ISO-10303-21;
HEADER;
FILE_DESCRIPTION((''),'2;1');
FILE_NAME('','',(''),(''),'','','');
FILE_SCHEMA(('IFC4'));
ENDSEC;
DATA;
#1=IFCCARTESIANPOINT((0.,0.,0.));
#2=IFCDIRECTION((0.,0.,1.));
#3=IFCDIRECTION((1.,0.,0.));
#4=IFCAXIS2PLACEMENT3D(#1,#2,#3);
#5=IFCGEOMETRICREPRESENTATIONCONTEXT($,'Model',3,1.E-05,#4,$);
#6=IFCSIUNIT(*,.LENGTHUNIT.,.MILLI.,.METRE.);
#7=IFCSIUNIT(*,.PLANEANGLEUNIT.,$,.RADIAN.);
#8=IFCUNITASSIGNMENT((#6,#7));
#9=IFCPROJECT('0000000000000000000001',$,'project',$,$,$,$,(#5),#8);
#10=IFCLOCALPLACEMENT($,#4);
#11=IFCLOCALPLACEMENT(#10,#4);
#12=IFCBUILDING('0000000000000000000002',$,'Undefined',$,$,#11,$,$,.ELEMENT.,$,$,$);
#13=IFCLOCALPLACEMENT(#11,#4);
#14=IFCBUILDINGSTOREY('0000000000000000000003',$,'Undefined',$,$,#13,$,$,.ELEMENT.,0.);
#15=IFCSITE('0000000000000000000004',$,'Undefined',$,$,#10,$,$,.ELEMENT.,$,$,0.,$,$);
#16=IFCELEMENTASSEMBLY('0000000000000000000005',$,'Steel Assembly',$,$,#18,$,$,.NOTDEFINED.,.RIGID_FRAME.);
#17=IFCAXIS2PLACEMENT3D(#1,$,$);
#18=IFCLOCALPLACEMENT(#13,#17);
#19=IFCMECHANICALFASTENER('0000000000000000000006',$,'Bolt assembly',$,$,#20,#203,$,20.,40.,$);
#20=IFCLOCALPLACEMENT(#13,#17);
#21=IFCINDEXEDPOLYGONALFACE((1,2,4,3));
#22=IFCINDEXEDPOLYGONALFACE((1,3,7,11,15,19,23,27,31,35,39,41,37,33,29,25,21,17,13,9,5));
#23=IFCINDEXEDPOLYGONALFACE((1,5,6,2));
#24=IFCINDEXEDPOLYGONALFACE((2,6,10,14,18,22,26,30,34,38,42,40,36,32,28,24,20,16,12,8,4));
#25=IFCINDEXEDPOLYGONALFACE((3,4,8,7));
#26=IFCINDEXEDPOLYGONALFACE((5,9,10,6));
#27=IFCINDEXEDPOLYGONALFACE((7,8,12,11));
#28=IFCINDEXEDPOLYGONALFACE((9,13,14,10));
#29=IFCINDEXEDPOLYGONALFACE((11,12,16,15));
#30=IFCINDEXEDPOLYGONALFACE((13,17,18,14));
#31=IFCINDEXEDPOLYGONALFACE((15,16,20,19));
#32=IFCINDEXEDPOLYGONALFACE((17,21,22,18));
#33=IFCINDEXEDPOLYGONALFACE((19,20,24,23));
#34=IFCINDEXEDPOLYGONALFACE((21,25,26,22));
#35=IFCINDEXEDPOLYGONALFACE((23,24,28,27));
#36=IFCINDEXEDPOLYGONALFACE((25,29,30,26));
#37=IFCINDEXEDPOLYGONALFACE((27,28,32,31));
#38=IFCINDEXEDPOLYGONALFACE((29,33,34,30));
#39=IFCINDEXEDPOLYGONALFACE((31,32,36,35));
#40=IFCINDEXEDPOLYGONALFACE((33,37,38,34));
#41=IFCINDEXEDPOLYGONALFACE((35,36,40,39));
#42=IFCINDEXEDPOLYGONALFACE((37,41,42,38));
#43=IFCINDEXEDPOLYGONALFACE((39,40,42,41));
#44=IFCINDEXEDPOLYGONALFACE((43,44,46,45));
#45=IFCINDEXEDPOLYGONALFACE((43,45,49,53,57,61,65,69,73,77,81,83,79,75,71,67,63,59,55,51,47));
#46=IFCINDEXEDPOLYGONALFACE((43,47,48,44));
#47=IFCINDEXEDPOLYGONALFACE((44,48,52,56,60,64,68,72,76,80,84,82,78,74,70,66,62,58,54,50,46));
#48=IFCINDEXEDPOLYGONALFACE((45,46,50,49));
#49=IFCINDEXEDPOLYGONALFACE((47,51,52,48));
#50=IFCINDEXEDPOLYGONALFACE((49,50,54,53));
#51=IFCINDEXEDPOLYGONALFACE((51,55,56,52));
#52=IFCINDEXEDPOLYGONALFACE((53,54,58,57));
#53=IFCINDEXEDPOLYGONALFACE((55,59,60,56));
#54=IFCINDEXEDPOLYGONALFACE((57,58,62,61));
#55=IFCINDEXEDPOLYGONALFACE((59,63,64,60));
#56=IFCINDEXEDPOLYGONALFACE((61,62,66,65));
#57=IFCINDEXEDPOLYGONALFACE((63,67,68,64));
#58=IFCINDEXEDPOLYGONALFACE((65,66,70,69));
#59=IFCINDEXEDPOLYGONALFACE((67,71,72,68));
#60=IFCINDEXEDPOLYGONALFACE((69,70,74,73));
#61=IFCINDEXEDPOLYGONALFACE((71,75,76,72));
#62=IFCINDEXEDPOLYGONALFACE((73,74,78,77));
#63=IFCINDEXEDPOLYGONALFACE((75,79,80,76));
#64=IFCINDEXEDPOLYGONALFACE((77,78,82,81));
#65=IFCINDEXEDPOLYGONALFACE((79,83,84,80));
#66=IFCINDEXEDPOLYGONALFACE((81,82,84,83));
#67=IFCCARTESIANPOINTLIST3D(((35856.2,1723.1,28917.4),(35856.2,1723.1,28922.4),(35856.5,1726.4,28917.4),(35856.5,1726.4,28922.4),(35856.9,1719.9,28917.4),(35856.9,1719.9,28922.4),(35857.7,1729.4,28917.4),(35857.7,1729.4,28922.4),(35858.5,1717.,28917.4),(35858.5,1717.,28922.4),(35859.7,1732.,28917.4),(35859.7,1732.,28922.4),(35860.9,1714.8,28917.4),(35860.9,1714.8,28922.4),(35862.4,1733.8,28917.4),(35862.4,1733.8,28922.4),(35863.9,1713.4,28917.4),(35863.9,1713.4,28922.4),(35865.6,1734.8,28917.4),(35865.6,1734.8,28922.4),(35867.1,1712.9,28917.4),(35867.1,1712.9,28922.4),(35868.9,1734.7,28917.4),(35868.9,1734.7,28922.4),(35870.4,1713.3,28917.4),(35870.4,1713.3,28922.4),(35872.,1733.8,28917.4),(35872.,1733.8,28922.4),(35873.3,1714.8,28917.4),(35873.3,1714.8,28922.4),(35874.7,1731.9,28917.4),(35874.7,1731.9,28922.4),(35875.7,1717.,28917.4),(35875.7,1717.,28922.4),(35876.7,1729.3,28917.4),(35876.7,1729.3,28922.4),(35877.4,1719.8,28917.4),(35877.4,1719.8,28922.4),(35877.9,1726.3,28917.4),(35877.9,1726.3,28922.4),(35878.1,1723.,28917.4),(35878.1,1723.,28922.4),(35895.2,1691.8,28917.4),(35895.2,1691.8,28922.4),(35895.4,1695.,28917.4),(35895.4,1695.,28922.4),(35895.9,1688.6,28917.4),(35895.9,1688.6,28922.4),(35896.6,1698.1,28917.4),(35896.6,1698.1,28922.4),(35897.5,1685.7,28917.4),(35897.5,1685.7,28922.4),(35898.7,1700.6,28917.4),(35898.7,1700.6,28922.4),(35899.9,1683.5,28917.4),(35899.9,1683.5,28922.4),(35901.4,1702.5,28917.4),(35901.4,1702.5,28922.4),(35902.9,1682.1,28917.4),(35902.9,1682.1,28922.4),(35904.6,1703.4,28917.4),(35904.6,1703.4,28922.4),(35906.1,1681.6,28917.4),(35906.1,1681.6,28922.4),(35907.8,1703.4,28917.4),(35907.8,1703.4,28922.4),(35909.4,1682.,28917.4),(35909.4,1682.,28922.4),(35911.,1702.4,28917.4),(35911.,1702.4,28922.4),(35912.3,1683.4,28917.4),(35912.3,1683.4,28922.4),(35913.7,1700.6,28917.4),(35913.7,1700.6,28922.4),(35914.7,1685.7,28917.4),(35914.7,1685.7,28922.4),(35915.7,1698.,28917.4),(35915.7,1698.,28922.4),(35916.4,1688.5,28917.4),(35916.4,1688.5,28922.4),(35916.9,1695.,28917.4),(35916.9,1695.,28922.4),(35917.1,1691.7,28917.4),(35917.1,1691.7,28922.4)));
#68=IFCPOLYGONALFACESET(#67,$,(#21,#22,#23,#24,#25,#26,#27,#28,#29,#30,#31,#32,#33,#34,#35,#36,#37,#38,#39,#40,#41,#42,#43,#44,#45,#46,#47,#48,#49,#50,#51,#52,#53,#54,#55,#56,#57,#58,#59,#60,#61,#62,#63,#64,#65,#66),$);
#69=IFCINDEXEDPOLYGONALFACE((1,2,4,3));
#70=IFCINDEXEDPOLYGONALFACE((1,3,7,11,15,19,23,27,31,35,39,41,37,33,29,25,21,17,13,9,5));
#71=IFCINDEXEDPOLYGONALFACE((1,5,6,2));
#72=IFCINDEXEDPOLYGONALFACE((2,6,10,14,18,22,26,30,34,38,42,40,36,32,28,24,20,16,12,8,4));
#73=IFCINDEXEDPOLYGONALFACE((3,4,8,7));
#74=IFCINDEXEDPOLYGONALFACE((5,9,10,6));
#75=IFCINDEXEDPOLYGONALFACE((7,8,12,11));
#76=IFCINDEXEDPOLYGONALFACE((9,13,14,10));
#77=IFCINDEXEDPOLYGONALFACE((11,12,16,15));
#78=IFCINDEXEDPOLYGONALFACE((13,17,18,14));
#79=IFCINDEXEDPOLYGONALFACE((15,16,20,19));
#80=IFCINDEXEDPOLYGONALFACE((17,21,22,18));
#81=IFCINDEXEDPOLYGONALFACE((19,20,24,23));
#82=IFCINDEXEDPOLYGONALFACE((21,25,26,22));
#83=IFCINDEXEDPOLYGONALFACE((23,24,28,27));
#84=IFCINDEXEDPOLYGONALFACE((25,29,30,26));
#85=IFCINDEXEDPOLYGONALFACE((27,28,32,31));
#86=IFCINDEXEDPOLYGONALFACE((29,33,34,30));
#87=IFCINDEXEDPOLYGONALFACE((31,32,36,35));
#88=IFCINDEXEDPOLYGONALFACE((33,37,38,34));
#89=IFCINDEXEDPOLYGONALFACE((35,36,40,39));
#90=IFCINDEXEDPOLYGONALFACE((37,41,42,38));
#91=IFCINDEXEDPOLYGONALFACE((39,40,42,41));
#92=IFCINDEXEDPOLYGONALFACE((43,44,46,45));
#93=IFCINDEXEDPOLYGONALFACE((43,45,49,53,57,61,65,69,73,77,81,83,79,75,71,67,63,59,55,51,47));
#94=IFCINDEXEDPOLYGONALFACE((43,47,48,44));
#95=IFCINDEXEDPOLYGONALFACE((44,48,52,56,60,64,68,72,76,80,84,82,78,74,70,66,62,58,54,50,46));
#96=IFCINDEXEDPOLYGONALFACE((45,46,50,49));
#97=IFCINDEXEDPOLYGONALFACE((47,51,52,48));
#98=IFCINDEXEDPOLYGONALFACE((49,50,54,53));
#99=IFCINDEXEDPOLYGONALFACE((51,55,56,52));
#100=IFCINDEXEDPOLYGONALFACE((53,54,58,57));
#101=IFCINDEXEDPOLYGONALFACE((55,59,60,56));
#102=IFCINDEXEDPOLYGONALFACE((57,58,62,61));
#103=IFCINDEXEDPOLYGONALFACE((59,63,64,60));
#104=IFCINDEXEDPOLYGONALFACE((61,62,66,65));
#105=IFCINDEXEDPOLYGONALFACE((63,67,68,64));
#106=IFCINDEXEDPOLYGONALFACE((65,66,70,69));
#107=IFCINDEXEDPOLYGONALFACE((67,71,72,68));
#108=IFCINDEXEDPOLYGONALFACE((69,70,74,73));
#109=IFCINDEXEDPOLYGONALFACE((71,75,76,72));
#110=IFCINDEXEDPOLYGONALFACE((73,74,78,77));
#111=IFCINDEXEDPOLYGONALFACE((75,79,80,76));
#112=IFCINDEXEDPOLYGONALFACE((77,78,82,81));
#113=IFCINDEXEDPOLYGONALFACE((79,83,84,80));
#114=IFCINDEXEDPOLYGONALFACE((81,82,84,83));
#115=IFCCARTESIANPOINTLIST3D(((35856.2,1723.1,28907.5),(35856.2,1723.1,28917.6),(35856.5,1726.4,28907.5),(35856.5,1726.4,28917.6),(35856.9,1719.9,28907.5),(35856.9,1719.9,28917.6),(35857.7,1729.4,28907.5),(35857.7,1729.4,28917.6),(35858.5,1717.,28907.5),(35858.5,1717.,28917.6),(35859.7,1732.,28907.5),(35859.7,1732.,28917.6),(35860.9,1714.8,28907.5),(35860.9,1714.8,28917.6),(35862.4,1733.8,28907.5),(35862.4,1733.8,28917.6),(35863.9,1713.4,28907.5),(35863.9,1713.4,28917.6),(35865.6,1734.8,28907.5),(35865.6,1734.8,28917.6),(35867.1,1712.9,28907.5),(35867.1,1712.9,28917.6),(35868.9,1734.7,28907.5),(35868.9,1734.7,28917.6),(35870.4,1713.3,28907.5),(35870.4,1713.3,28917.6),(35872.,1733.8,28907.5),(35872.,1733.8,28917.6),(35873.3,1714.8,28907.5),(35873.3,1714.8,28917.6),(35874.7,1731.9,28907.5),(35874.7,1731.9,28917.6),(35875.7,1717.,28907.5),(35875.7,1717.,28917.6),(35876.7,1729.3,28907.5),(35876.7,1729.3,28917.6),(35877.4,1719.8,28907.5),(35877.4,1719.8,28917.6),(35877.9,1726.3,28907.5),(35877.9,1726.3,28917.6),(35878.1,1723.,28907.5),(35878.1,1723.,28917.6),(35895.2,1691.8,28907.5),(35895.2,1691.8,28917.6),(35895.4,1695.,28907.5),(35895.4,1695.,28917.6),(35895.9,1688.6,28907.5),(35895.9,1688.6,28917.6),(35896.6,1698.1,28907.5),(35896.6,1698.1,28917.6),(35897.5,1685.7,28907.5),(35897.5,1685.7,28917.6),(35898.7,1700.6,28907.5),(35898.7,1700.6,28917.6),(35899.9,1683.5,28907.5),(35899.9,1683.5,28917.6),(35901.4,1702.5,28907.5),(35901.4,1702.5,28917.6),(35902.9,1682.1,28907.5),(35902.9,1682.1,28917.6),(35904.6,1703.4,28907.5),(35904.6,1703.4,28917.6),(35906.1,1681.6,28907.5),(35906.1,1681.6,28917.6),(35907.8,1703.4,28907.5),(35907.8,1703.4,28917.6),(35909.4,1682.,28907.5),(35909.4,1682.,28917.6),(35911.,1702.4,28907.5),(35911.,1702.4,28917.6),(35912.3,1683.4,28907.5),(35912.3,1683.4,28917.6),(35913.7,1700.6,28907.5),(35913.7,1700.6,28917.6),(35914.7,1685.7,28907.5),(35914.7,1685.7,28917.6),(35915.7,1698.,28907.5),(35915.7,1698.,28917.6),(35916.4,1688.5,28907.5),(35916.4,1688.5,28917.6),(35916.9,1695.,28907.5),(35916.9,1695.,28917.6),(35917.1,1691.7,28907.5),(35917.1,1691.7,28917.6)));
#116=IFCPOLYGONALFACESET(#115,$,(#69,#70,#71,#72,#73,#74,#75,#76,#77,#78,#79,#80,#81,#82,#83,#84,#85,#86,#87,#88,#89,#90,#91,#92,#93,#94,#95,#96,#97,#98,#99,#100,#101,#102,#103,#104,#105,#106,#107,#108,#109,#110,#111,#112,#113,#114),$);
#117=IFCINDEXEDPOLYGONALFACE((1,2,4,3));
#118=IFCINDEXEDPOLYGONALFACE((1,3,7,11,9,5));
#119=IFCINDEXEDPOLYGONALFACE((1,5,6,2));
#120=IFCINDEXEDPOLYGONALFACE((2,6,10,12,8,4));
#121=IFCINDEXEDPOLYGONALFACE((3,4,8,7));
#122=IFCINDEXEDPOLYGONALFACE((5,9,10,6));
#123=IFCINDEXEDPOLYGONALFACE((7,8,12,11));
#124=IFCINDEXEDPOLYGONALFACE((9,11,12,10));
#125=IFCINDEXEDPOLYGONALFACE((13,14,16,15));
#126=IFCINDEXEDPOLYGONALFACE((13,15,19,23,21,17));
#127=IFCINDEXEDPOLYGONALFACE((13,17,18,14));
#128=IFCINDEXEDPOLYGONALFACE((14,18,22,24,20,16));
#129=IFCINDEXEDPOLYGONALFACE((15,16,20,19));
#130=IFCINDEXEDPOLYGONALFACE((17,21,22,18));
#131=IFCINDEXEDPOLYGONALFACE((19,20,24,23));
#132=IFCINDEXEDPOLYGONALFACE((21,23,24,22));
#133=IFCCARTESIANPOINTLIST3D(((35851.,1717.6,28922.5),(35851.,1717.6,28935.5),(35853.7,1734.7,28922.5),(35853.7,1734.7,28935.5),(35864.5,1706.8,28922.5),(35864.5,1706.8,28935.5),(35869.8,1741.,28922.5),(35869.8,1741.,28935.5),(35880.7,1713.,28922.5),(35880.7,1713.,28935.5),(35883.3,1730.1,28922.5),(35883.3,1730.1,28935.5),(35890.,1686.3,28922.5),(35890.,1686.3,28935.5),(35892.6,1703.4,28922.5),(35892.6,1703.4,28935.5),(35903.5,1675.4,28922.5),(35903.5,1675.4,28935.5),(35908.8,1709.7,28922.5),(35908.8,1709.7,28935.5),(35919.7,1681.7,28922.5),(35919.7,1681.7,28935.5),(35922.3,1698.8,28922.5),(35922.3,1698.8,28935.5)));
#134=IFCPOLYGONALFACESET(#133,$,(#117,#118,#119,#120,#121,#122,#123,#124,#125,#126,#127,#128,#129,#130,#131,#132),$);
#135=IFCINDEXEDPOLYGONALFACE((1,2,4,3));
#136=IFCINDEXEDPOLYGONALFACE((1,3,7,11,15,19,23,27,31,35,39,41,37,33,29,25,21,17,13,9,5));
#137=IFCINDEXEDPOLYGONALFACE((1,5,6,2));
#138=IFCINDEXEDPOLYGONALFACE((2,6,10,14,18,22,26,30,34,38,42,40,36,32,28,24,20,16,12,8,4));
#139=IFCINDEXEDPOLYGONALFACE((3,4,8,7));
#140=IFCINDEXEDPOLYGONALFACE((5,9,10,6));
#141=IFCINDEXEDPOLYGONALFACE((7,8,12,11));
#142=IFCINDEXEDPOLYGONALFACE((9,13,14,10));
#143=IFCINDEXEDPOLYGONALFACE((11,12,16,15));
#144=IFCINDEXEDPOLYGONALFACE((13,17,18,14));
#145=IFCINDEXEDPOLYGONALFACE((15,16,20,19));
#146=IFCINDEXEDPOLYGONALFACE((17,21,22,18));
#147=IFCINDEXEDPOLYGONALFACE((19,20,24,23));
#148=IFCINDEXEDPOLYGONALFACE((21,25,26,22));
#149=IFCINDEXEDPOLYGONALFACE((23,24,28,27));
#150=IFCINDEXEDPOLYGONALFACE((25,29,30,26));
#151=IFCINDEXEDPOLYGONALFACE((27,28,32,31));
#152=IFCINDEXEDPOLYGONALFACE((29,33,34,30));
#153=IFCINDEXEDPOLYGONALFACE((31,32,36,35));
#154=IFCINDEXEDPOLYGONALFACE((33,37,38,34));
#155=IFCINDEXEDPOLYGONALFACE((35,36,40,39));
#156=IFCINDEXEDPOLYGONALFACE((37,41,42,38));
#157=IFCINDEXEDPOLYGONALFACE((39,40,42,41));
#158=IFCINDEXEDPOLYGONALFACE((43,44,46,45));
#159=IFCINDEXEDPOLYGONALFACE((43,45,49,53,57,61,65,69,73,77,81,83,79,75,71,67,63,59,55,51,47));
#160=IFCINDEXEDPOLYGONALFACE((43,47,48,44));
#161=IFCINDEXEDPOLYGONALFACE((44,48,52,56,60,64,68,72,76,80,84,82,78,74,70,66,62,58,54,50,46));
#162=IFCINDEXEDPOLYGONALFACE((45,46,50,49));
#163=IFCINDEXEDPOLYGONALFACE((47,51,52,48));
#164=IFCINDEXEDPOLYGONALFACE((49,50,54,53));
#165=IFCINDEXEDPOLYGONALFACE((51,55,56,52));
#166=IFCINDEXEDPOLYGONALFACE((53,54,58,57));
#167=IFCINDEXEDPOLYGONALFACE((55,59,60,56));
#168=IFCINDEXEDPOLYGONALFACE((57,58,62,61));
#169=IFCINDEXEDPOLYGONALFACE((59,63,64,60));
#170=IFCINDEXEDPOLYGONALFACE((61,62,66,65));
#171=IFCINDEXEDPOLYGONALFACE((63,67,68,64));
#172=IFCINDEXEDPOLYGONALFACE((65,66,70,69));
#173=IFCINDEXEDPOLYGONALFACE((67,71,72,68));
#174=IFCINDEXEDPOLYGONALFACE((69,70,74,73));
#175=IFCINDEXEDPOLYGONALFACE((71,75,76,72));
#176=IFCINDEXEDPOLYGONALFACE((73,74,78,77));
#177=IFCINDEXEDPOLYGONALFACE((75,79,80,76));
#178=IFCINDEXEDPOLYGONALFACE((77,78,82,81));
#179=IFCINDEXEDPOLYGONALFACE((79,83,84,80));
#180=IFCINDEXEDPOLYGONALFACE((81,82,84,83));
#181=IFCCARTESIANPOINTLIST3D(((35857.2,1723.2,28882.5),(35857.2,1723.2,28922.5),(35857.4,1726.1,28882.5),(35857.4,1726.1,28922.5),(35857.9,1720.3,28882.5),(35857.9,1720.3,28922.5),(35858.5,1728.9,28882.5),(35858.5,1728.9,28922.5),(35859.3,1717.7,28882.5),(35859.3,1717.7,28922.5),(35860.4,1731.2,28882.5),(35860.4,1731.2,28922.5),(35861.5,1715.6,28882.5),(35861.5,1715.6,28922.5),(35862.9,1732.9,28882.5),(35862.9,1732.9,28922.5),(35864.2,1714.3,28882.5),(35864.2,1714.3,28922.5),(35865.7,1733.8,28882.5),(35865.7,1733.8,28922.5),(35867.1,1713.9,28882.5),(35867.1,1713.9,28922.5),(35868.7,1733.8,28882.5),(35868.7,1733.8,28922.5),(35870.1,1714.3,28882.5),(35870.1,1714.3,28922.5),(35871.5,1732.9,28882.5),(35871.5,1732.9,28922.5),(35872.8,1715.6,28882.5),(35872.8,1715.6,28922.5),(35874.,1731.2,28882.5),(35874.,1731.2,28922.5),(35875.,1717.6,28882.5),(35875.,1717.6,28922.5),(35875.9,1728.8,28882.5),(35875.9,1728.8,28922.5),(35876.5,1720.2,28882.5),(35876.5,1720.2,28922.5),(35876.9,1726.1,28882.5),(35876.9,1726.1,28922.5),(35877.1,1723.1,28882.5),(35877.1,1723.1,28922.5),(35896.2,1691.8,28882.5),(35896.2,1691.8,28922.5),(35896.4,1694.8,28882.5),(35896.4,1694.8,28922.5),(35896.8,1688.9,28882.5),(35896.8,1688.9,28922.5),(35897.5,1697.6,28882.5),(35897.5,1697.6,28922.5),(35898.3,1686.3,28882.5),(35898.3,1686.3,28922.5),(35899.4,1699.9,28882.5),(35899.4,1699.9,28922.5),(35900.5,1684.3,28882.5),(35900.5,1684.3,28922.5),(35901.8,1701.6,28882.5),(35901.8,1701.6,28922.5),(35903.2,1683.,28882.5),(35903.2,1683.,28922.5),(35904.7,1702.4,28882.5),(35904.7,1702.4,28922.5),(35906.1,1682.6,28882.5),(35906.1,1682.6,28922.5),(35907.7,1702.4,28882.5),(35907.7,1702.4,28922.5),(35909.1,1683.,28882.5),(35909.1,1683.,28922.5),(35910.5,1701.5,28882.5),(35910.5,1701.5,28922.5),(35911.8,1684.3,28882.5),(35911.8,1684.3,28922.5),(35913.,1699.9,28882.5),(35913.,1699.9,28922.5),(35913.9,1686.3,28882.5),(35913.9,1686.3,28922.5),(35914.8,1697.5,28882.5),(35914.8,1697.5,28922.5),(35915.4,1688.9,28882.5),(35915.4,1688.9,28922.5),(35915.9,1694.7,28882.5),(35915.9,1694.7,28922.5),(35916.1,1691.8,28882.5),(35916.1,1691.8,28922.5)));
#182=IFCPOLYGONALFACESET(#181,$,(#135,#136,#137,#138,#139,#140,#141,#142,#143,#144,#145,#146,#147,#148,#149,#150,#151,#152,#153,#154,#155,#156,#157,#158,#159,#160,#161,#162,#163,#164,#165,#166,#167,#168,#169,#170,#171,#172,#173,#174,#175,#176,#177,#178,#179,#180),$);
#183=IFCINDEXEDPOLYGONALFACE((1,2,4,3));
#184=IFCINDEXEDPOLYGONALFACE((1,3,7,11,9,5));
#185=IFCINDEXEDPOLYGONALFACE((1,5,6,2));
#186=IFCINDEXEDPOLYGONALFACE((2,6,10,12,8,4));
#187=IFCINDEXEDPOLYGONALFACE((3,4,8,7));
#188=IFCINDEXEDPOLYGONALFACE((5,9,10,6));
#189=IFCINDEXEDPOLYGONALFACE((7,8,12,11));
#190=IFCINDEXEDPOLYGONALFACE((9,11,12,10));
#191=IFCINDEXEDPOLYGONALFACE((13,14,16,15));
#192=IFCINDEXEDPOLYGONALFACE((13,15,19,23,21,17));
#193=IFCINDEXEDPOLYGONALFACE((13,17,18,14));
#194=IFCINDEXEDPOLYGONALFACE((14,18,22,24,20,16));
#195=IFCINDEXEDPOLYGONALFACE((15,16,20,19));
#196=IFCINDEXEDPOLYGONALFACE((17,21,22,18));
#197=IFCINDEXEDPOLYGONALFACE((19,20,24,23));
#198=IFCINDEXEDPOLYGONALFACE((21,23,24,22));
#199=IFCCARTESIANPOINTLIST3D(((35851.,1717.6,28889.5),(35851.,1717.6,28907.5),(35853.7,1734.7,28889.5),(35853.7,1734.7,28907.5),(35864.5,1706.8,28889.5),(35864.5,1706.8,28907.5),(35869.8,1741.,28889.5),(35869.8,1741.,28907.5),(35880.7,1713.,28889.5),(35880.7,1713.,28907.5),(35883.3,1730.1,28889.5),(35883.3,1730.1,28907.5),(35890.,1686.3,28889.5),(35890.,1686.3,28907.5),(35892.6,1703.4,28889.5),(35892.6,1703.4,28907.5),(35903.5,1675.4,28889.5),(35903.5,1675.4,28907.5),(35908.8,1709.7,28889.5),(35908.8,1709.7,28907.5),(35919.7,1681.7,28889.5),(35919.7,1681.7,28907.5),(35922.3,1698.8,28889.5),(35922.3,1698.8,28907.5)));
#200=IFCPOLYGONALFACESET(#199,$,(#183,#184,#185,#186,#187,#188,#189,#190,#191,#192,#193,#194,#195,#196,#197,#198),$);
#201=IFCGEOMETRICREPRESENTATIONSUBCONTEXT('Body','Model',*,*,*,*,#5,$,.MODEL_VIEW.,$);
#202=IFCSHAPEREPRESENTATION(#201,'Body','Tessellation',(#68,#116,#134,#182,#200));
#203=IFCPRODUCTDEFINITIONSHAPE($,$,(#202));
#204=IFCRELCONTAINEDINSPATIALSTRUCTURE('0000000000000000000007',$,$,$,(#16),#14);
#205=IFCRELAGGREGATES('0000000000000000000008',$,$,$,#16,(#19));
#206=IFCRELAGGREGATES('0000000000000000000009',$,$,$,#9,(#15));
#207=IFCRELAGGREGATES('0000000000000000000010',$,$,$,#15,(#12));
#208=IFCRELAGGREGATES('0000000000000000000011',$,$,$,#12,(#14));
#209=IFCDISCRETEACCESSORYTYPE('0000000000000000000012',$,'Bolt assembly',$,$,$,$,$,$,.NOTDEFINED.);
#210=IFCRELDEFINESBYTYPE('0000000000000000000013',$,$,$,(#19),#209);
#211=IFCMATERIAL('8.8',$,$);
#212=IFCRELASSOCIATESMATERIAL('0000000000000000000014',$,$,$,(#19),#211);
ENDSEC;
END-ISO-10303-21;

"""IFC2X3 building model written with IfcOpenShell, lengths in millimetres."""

from ifc_helpers import new_model, si_unit, frame, origin_with_axes, origin_2d_with_axis, place, context, subcontext, project, spatial, polyline, circle, outline, extrude, source, transform, mapped, material, type_object, element, aggregate, save


model = new_model("IFC2X3")

# Units and contexts
model_context = context("Model", 3, precision=1e-05, world=origin_with_axes())
body_context = subcontext(model_context, "Body", "Model", "MODEL_VIEW")
ifc_project = project(units=[si_unit("LENGTHUNIT", "METRE", prefix="MILLI"), si_unit("PLANEANGLEUNIT", "RADIAN")], contexts=[model_context])

# Site, building, storey
site_placement = place(None, origin_with_axes())
site = spatial("IfcSite", under=ifc_project, at=site_placement, Name="Undefined", CompositionType="ELEMENT", RefElevation=0.0)
building_placement = place(site_placement, origin_with_axes())
building = spatial("IfcBuilding", under=site, at=building_placement, Name="Undefined", CompositionType="ELEMENT")
storey_placement = place(building_placement, origin_with_axes())
storey = spatial("IfcBuildingStorey", under=building, at=storey_placement, Name="Undefined", CompositionType="ELEMENT", Elevation=0.0)

# Shared definitions
discrete_accessory_type_1 = type_object("IfcDiscreteAccessoryType", Name="Bolt assembly")

# Shared definitions
ifc_material_1 = material(Name="8.8")

# Element assembly, mechanical fastener
assembly_1_placement = place(storey_placement, origin_with_axes())
assembly_1 = element("IfcElementAssembly", 1, at=assembly_1_placement, inside=storey, Name="Steel Assembly", AssemblyPlace="NOTDEFINED", PredefinedType="RIGID_FRAME")
shared_shape_1 = source(origin_with_axes(), body_context, "Body", "SweptSolid", [
    extrude(circle(Radius=11.0, at=origin_2d_with_axis()), frame((0.0, 0.1, 0.0), z_axis=(0.0, 1.0, 0.0), x_axis=(1.0, 0.0, 0.0)), (0.0, 0.0, 1.0), 5.0),
    extrude(circle(Radius=11.0, at=origin_2d_with_axis()), frame((0.0, 4.9, 0.0), z_axis=(0.0, 1.0, 0.0), x_axis=(1.0, 0.0, 0.0)), (0.0, 0.0, 1.0), 10.1),
    extrude(outline(polyline([(17.3, 0.0), (8.7, 15.0), (-8.7, 15.0), (-17.3, 0.0), (-8.7, -15.0), (8.7, -15.0), (17.3, 0.0)])), frame((0.0, -13.0, 0.0), z_axis=(0.0, 1.0, 0.0), x_axis=(1.0, 0.0, 0.0)), (0.0, 0.0, 1.0), 13.0),
    extrude(circle(Radius=10.0, at=origin_2d_with_axis()), frame((0.0, 0.0, 0.0), z_axis=(0.0, 1.0, 0.0), x_axis=(1.0, 0.0, 0.0)), (0.0, 0.0, 1.0), 40.0),
    extrude(outline(polyline([(17.3, 0.0), (8.7, 15.0), (-8.7, 15.0), (-17.3, 0.0), (-8.7, -15.0), (8.7, -15.0), (17.3, 0.0)])), frame((0.0, 15.0, 0.0), z_axis=(0.0, 1.0, 0.0), x_axis=(1.0, 0.0, 0.0)), (0.0, 0.0, 1.0), 18.0),
])
mechanical_fastener_1_placement = place(assembly_1_placement, frame((35867.2, 1723.9, 28922.5), z_axis=(0.626358, 0.779536, 0.0), x_axis=(0.779536, -0.626358, 0.0)))
mechanical_fastener_1 = element("IfcMechanicalFastener", 2, at=mechanical_fastener_1_placement, type_object=discrete_accessory_type_1, material=ifc_material_1, Name="Bolt assembly", NominalDiameter=20.0, NominalLength=40.0, context=body_context, shape_type="MappedRepresentation", body=[
    mapped(shared_shape_1, transform((0.0, 0.0, 0.0))),
    mapped(shared_shape_1, transform((50.0, 0.0, 0.0))),
])
aggregate(assembly_1, [mechanical_fastener_1])

save(model, "model.ifc")
